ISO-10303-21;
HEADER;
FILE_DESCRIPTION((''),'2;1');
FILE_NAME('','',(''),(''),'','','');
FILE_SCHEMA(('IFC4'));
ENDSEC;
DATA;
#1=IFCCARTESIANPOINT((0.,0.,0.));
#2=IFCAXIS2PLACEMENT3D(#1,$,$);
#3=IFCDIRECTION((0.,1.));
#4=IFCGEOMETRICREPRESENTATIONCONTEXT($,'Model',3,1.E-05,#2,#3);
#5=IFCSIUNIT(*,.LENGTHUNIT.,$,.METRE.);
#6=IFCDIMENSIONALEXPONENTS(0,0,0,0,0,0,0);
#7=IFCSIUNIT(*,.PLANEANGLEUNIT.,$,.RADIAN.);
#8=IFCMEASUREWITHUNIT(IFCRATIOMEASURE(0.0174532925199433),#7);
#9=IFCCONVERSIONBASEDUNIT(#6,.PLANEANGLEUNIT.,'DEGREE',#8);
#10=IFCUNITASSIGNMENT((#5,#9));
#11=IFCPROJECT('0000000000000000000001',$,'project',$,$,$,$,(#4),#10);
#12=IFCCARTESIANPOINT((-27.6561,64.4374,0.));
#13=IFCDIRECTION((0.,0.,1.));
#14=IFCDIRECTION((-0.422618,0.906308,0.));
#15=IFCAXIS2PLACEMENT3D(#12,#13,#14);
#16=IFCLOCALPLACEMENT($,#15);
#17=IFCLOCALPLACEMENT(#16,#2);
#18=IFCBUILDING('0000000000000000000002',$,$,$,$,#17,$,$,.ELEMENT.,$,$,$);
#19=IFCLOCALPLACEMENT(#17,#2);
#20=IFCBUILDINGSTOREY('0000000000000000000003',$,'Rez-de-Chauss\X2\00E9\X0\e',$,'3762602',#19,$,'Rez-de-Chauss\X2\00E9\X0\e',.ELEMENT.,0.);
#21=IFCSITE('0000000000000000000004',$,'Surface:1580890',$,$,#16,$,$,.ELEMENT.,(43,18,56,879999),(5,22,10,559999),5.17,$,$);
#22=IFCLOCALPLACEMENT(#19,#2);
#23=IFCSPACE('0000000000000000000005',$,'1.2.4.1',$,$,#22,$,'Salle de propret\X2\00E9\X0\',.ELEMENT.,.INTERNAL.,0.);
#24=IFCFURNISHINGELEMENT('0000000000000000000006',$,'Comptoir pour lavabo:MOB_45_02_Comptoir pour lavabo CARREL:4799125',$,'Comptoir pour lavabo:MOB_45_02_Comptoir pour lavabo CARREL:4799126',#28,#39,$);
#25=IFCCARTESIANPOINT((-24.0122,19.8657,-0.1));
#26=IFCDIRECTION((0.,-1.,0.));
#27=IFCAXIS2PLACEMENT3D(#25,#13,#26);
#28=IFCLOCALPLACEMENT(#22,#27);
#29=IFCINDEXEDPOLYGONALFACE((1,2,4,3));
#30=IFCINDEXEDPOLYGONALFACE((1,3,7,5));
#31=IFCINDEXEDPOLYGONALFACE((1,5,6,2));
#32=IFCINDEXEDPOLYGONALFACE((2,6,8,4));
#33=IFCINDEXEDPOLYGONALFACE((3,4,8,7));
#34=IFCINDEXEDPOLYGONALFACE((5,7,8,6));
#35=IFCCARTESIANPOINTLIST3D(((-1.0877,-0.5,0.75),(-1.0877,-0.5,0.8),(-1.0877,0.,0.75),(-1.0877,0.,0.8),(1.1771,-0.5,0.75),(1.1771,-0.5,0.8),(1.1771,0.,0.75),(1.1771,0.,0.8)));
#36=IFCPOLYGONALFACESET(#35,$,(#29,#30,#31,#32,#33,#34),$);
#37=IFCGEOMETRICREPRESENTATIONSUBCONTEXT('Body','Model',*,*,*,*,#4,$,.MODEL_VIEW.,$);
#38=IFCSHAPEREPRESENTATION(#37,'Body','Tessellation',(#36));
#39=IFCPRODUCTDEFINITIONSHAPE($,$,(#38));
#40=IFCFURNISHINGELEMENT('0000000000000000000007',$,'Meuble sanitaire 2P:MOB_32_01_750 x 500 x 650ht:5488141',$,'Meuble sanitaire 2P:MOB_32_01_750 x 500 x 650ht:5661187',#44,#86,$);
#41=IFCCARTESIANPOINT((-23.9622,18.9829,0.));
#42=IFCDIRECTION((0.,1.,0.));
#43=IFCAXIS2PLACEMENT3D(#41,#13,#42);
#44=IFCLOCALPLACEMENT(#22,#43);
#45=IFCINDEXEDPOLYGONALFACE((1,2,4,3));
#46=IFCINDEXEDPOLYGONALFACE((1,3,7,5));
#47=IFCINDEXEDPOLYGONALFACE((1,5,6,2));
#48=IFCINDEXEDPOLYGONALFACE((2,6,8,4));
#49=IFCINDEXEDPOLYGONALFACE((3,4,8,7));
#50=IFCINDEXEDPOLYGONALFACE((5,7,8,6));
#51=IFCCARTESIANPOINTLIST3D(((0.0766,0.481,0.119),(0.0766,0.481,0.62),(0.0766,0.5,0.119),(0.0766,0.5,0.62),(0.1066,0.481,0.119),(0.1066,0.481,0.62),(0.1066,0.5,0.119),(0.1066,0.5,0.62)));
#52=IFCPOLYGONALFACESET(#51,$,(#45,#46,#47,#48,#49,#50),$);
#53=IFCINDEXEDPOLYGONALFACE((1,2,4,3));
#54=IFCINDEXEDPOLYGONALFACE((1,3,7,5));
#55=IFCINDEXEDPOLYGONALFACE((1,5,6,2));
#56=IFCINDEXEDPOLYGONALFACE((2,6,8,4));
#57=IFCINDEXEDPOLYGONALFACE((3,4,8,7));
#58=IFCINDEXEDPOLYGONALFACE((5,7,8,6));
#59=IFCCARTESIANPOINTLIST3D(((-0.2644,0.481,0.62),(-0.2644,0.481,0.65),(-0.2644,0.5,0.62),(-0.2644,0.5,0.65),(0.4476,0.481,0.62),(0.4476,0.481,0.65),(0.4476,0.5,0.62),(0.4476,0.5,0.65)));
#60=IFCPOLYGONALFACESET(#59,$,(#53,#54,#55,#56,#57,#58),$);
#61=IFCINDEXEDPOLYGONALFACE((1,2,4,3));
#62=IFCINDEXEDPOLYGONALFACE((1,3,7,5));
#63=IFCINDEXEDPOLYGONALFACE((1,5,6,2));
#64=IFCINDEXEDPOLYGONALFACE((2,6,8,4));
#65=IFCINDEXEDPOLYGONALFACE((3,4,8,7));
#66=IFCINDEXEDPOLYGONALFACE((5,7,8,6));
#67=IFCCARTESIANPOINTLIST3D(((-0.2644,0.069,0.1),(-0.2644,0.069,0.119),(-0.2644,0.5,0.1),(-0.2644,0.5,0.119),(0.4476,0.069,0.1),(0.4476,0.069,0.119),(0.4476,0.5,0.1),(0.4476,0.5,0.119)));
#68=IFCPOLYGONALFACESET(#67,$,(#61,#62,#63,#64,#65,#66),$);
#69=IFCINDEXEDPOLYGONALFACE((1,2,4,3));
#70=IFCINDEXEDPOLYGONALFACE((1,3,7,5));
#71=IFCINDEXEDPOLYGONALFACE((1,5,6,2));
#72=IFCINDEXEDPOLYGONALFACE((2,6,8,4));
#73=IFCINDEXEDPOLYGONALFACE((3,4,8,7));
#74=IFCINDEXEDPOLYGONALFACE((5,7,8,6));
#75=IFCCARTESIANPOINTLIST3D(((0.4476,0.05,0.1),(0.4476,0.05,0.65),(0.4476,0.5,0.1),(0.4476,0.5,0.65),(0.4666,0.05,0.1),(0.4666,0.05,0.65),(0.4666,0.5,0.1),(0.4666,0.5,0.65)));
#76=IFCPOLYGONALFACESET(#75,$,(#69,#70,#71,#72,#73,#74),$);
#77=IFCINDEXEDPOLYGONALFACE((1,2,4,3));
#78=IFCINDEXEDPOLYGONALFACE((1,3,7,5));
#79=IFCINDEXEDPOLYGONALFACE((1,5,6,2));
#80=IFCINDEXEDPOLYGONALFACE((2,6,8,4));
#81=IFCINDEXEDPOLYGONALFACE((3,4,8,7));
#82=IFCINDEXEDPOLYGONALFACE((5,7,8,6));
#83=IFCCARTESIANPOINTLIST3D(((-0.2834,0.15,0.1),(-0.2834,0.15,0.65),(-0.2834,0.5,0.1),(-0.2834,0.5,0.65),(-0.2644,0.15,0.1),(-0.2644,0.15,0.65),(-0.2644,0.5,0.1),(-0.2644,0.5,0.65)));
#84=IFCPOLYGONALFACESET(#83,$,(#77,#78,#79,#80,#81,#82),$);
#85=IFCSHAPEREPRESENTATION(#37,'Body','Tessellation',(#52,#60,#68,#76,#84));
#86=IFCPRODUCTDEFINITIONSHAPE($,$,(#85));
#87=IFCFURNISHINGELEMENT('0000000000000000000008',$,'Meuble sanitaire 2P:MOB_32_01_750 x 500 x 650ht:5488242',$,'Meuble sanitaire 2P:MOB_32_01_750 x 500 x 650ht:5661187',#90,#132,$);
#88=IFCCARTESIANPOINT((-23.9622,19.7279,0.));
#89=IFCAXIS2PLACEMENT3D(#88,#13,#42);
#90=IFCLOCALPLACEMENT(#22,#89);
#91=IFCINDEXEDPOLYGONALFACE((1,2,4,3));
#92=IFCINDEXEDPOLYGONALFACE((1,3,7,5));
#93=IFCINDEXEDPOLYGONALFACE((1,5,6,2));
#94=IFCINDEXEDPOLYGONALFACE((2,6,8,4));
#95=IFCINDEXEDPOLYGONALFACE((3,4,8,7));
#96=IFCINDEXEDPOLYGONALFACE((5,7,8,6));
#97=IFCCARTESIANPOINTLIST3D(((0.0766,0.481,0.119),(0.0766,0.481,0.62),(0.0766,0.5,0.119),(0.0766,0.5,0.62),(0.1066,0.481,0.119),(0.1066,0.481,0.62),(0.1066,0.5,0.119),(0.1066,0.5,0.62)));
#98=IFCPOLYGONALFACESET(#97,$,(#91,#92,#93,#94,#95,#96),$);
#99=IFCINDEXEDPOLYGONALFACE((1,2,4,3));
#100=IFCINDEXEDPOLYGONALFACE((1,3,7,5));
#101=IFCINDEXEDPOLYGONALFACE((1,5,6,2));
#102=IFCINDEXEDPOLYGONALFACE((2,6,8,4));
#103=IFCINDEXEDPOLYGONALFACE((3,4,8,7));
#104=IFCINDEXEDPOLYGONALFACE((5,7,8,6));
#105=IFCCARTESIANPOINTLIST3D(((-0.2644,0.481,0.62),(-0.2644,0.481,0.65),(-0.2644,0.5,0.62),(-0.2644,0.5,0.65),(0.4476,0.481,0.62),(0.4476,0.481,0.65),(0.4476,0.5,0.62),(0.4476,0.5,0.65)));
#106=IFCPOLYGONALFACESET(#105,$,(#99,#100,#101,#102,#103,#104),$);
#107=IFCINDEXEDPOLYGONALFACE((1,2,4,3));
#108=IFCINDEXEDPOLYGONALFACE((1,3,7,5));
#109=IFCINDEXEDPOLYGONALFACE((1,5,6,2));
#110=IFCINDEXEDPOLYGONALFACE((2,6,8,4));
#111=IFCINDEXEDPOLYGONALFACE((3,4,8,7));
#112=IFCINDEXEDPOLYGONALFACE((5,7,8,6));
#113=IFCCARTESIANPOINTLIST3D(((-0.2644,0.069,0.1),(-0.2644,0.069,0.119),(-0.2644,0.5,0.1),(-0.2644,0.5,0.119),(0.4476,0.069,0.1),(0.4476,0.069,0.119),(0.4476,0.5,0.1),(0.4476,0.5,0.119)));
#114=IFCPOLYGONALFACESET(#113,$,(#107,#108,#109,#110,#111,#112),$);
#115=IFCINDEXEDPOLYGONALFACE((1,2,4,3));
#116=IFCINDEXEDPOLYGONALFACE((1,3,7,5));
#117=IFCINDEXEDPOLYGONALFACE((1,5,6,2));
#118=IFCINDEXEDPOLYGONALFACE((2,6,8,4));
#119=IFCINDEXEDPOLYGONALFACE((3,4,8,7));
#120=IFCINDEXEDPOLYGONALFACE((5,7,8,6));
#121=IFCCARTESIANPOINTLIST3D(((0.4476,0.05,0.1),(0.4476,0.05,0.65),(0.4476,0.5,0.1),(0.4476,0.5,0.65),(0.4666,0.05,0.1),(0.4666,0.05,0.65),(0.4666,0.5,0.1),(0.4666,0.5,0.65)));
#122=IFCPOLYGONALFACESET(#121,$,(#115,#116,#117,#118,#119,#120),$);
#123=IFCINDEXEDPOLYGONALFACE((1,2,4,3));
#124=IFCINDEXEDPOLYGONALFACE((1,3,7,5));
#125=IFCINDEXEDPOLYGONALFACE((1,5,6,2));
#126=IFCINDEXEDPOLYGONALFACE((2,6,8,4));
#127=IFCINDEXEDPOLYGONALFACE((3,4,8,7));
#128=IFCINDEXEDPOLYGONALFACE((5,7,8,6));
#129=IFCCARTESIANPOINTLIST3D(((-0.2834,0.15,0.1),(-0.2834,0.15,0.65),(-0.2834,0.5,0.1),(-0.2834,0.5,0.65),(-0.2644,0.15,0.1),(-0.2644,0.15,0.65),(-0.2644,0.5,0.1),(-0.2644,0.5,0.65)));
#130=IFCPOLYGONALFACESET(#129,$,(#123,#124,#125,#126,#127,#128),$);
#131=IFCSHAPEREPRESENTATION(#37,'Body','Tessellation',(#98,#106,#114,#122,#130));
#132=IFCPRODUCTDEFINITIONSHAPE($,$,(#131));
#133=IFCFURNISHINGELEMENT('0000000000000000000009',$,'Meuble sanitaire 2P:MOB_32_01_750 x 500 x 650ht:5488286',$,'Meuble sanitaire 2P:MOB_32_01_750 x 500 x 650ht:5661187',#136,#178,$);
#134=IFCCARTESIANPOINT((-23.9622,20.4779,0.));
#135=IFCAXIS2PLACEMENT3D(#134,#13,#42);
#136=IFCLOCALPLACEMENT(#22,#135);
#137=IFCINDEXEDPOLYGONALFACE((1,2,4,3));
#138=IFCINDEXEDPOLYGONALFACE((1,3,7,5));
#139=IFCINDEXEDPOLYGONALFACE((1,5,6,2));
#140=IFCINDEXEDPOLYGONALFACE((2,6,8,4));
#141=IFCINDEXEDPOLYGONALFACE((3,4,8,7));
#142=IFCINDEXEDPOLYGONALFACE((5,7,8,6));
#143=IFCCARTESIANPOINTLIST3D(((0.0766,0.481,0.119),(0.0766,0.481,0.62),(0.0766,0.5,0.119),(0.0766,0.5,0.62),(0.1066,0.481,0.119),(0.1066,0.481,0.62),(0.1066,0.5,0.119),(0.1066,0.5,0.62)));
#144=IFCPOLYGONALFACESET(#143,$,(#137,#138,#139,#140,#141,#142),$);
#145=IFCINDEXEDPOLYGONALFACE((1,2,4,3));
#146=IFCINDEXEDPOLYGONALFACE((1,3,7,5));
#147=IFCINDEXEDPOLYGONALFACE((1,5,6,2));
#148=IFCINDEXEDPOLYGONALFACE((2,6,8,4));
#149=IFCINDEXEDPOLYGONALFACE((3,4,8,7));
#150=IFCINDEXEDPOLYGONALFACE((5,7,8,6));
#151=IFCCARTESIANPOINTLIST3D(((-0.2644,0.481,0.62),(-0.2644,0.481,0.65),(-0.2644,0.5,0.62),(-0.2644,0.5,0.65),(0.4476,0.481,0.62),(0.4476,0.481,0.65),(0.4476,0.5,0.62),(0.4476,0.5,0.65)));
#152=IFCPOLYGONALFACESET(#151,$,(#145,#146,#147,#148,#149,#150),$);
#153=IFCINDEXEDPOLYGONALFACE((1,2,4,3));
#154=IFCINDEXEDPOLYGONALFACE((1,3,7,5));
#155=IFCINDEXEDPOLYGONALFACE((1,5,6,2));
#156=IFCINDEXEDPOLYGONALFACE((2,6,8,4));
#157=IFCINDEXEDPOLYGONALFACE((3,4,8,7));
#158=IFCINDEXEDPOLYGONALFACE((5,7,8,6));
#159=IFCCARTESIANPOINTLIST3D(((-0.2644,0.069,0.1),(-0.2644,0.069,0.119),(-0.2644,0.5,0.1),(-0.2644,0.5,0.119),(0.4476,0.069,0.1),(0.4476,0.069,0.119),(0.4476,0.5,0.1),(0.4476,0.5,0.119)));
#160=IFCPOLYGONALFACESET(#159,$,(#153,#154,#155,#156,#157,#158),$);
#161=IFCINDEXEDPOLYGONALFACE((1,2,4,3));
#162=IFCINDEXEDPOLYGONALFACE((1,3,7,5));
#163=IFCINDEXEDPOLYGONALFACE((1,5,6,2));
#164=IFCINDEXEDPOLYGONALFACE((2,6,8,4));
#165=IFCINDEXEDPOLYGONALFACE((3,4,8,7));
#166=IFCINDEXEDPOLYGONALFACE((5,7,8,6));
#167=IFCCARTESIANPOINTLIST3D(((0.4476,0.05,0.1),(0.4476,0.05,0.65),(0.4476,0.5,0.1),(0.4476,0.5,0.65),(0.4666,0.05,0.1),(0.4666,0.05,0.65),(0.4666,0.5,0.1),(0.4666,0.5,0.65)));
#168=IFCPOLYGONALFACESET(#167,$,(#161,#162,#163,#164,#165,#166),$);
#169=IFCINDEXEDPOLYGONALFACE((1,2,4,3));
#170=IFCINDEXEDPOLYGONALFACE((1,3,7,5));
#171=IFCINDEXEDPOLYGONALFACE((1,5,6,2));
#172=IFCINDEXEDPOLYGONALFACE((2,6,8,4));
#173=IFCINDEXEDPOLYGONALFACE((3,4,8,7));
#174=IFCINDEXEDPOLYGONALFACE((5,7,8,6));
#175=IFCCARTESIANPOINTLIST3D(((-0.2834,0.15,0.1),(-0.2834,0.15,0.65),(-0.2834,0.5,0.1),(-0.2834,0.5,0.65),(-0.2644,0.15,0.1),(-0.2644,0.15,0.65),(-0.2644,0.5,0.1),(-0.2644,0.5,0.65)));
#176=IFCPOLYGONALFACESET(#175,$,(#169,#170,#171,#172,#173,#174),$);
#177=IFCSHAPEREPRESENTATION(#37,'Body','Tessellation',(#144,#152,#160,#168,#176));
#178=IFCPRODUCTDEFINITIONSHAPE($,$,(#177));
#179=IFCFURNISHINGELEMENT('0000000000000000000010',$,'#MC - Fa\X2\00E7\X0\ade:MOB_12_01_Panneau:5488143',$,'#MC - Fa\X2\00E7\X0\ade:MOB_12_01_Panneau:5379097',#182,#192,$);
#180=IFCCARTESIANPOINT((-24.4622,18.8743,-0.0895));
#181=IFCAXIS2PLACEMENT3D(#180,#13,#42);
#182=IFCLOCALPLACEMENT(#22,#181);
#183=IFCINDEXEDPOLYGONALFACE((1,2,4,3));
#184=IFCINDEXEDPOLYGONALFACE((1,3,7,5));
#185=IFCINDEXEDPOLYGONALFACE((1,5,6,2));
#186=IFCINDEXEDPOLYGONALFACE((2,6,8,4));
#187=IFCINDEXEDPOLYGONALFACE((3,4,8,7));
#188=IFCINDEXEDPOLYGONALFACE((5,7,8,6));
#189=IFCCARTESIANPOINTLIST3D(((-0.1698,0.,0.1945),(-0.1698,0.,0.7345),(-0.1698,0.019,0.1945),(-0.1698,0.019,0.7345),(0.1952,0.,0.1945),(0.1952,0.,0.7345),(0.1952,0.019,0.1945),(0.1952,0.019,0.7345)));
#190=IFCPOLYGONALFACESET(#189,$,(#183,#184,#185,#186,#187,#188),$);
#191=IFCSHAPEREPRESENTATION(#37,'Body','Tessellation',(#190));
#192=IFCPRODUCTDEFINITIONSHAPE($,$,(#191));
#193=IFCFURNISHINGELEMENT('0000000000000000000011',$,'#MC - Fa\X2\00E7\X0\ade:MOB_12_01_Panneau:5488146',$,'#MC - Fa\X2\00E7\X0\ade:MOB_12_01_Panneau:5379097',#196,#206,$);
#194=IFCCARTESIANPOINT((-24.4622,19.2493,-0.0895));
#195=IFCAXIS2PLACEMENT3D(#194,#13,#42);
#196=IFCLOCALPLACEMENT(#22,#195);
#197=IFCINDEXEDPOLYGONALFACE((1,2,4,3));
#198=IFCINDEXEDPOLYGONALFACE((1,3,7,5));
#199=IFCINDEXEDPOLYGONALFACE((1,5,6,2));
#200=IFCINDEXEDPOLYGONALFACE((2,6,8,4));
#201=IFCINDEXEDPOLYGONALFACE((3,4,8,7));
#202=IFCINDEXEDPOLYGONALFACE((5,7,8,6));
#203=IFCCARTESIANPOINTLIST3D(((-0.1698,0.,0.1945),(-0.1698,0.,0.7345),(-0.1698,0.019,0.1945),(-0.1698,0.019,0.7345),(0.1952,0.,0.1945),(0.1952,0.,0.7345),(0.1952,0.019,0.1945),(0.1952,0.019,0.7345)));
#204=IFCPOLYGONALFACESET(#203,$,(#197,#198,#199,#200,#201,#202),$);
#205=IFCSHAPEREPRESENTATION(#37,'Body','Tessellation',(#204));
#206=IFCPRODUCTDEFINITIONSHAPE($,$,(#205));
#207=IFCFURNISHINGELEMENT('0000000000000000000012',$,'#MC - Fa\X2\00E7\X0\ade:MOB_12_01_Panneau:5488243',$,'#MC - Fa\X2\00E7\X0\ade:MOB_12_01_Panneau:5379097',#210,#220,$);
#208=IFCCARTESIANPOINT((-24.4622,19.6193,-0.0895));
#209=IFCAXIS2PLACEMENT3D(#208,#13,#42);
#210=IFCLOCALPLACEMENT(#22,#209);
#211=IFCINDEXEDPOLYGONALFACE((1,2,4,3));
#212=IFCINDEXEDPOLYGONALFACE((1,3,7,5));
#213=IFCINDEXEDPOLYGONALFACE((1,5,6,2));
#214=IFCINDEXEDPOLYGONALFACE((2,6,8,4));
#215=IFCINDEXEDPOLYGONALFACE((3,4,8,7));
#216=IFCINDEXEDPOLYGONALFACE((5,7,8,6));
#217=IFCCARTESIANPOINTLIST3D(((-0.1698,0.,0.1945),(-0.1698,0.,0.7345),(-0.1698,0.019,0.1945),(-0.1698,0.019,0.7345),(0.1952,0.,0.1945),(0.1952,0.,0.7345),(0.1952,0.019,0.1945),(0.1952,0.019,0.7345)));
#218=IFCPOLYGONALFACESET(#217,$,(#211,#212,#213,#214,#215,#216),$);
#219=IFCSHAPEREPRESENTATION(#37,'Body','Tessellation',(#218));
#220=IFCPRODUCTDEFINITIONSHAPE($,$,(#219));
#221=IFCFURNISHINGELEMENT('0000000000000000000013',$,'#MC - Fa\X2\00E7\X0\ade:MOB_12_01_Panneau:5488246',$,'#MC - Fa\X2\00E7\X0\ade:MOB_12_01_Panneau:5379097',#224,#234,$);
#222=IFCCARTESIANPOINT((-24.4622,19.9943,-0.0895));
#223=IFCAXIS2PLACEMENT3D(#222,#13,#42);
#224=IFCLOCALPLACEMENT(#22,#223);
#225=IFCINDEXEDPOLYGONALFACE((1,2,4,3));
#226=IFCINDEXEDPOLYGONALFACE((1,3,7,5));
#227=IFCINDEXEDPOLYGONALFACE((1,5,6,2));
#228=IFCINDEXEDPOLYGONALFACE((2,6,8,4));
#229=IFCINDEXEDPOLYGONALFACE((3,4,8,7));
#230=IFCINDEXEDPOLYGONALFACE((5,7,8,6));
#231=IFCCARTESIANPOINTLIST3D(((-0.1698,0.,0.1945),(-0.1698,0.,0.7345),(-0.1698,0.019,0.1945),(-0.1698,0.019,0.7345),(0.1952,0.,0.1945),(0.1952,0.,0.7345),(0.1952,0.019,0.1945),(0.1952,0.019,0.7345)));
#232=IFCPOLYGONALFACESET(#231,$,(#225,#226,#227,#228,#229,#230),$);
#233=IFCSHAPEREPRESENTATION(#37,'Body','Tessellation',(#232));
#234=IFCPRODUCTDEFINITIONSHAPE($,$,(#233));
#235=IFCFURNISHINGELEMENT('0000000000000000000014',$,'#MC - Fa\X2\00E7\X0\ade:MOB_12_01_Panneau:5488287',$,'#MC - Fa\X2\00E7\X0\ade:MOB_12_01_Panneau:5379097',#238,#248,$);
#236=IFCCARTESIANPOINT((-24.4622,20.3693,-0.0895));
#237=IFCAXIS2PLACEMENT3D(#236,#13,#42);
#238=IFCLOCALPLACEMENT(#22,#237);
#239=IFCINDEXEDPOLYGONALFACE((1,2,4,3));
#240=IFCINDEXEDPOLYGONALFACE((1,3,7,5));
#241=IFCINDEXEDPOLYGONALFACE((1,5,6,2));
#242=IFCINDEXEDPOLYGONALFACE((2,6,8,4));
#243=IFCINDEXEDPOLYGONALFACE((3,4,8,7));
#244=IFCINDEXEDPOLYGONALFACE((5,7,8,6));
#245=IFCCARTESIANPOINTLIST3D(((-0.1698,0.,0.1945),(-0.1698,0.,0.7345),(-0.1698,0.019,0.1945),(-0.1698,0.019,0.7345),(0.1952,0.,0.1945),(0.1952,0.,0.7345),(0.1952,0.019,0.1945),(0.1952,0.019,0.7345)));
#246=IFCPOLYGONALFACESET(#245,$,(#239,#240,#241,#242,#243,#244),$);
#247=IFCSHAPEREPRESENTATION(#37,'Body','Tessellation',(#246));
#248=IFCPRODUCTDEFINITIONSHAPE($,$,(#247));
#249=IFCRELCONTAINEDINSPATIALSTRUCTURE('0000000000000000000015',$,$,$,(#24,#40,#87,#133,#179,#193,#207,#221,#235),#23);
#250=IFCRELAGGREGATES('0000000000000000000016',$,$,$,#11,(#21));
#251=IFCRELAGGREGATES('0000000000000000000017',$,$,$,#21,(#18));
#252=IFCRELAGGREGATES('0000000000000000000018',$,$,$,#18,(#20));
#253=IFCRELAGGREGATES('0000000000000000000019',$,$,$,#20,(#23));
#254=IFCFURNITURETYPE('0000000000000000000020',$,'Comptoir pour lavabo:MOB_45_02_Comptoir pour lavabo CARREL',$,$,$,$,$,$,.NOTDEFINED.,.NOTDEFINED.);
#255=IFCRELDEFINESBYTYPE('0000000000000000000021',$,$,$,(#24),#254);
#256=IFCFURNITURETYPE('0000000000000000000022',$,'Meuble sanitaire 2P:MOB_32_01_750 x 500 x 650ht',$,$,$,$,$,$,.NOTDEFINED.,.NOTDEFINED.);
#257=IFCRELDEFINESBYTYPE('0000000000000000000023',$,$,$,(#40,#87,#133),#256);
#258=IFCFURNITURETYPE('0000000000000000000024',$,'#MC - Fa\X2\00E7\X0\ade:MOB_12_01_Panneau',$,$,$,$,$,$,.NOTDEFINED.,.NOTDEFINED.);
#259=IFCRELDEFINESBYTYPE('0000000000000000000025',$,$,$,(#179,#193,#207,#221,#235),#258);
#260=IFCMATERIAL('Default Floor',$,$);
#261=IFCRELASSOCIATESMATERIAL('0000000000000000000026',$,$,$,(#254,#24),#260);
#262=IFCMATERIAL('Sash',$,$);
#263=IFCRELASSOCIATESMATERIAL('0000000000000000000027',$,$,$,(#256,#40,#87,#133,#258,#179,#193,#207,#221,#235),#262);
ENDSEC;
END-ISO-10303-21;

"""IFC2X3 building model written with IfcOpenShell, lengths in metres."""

from ifc_helpers import new_model, entity, si_unit, converted_unit, direction, frame, frame_2d, origin, origin_2d_with_axis, place, context, subcontext, project, spatial, rectangle, extrude, source, transform, mapped, material, type_object, type_shapes, element, save


model = new_model("IFC2X3")

# Units and contexts
model_context = context("Model", 3, precision=1e-05, world=origin(), true_north=direction((0.0, 1.0)))
body_context = subcontext(model_context, "Body", "Model", "MODEL_VIEW")
ifc_project = project(units=[si_unit("LENGTHUNIT", "METRE"), converted_unit("PLANEANGLEUNIT", "DEGREE", entity("IfcRatioMeasure", 0.0174532925199433), si_unit("PLANEANGLEUNIT", "RADIAN"), dimensions=[0, 0, 0, 0, 0, 0, 0])], contexts=[model_context])

# Site, building, storey
site_placement = place(None, frame((-27.6561, 64.4374, 0.0), z_axis=(0.0, 0.0, 1.0), x_axis=(-0.422618, 0.906308, 0.0)))
site = spatial("IfcSite", under=ifc_project, at=site_placement, Name="Surface:1580890", CompositionType="ELEMENT", RefLatitude=(43, 18, 56, 879999), RefLongitude=(5, 22, 10, 559999), RefElevation=5.17)
building_placement = place(site_placement, origin())
building = spatial("IfcBuilding", under=site, at=building_placement, CompositionType="ELEMENT")
storey_placement = place(building_placement, origin())
storey = spatial("IfcBuildingStorey", under=building, at=storey_placement, Name="Rez-de-Chaussée", ObjectType="3762602", LongName="Rez-de-Chaussée", CompositionType="ELEMENT", Elevation=0.0)

# Shared definitions
ifc_material_1 = material(Name="Sash")

# Shared definitions
space_placement = place(storey_placement, origin())
space = spatial("IfcSpace", under=storey, at=space_placement, Name="1.2.4.1", LongName="Salle de propreté", CompositionType="ELEMENT", InteriorOrExteriorSpace="INTERNAL", ElevationWithFlooring=0.0)

# Furnishing elements
ifc_material_2 = material(Name="Default Floor")
furniture_type_1 = type_object("IfcFurnitureType", Name="Comptoir pour lavabo:MOB_45_02_Comptoir pour lavabo CARREL", material=ifc_material_2)
shared_shape_1 = source(origin(), body_context, "Body", "SweptSolid", [
    extrude(rectangle(XDim=2.2649, YDim=0.5, at=origin_2d_with_axis()), frame((0.0447, -0.25, 0.75), z_axis=(0.0, 0.0, 1.0), x_axis=(-1.0, 0.0, 0.0)), (0.0, 0.0, 1.0), 0.05),
])
type_shapes(furniture_type_1, [shared_shape_1])
furnishing_placement = place(space_placement, frame((-24.0122, 19.8657, -0.1), z_axis=(0.0, 0.0, 1.0), x_axis=(0.0, -1.0, 0.0)))
element("IfcFurnishingElement", 1, at=furnishing_placement, inside=space, type_object=furniture_type_1, material=ifc_material_2, Name="Comptoir pour lavabo:MOB_45_02_Comptoir pour lavabo CARREL:4799125", ObjectType="Comptoir pour lavabo:MOB_45_02_Comptoir pour lavabo CARREL:4799126", context=body_context, shape_type="MappedRepresentation", body=[
    mapped(shared_shape_1, transform((0.0, 0.0, 0.0), scale=1.0)),
])
furniture_type_2 = type_object("IfcFurnitureType", Name="Meuble sanitaire 2P:MOB_32_01_750 x 500 x 650ht", material=ifc_material_1)
shared_shape_2 = source(origin(), body_context, "Body", "SweptSolid", [
    extrude(rectangle(XDim=0.019, YDim=0.03, at=frame_2d((0.0, 0.0), x_axis=(1.0, 0.0))), frame((0.0916, 0.4905, 0.119), z_axis=(0.0, 0.0, 1.0), x_axis=(0.0, 1.0, 0.0)), (0.0, 0.0, 1.0), 0.501),
    extrude(rectangle(XDim=0.019, YDim=0.712, at=origin_2d_with_axis()), frame((0.0916, 0.4905, 0.62), z_axis=(0.0, 0.0, 1.0), x_axis=(0.0, 1.0, 0.0)), (0.0, 0.0, 1.0), 0.03),
    extrude(rectangle(XDim=0.712, YDim=0.431, at=origin_2d_with_axis()), frame((0.0916, 0.2845, 0.1), z_axis=(0.0, 0.0, 1.0), x_axis=(-1.0, 0.0, 0.0)), (0.0, 0.0, 1.0), 0.019),
    extrude(rectangle(XDim=0.019, YDim=0.45, at=origin_2d_with_axis()), frame((0.4571, 0.275, 0.1), z_axis=(0.0, 0.0, 1.0), x_axis=(-1.0, 0.0, 0.0)), (0.0, 0.0, 1.0), 0.55),
    extrude(rectangle(XDim=0.019, YDim=0.35, at=origin_2d_with_axis()), frame((-0.2739, 0.325, 0.1), z_axis=(0.0, 0.0, 1.0), x_axis=(-1.0, 0.0, 0.0)), (0.0, 0.0, 1.0), 0.55),
])
type_shapes(furniture_type_2, [shared_shape_2])
for number, where, z_axis, x_axis, name in (
    (2, (-23.9622, 18.9829, 0.0), (0.0, 0.0, 1.0), (0.0, 1.0, 0.0), "Meuble sanitaire 2P:MOB_32_01_750 x 500 x 650ht:5488141"),
    (3, (-23.9622, 19.7279, 0.0), (0.0, 0.0, 1.0), (0.0, 1.0, 0.0), "Meuble sanitaire 2P:MOB_32_01_750 x 500 x 650ht:5488242"),
    (4, (-23.9622, 20.4779, 0.0), (0.0, 0.0, 1.0), (0.0, 1.0, 0.0), "Meuble sanitaire 2P:MOB_32_01_750 x 500 x 650ht:5488286"),
):
    element("IfcFurnishingElement", number, at=place(space_placement, frame(where, z_axis=z_axis, x_axis=x_axis)), inside=space, type_object=furniture_type_2, material=ifc_material_1, Name=name, ObjectType="Meuble sanitaire 2P:MOB_32_01_750 x 500 x 650ht:5661187", context=body_context, shape_type="MappedRepresentation", body=[
        mapped(shared_shape_2, transform((0.0, 0.0, 0.0), scale=1.0)),
    ])
furniture_type_3 = type_object("IfcFurnitureType", Name="#MC - Façade:MOB_12_01_Panneau", material=ifc_material_1)
shared_shape_3 = source(origin(), body_context, "Body", "SweptSolid", [
    extrude(rectangle(XDim=0.019, YDim=0.365, at=origin_2d_with_axis()), frame((0.0127, 0.0095, 0.1945), z_axis=(0.0, 0.0, 1.0), x_axis=(0.0, 1.0, 0.0)), (0.0, 0.0, 1.0), 0.54),
])
type_shapes(furniture_type_3, [shared_shape_3])
for number, where, z_axis, x_axis, name in (
    (5, (-24.4622, 18.8743, -0.0895), (0.0, 0.0, 1.0), (0.0, 1.0, 0.0), "#MC - Façade:MOB_12_01_Panneau:5488143"),
    (6, (-24.4622, 19.2493, -0.0895), (0.0, 0.0, 1.0), (0.0, 1.0, 0.0), "#MC - Façade:MOB_12_01_Panneau:5488146"),
    (7, (-24.4622, 19.6193, -0.0895), (0.0, 0.0, 1.0), (0.0, 1.0, 0.0), "#MC - Façade:MOB_12_01_Panneau:5488243"),
    (8, (-24.4622, 19.9943, -0.0895), (0.0, 0.0, 1.0), (0.0, 1.0, 0.0), "#MC - Façade:MOB_12_01_Panneau:5488246"),
    (9, (-24.4622, 20.3693, -0.0895), (0.0, 0.0, 1.0), (0.0, 1.0, 0.0), "#MC - Façade:MOB_12_01_Panneau:5488287"),
):
    element("IfcFurnishingElement", number, at=place(space_placement, frame(where, z_axis=z_axis, x_axis=x_axis)), inside=space, type_object=furniture_type_3, material=ifc_material_1, Name=name, ObjectType="#MC - Façade:MOB_12_01_Panneau:5379097", context=body_context, shape_type="MappedRepresentation", body=[
        mapped(shared_shape_3, transform((0.0, 0.0, 0.0), scale=1.0)),
    ])

save(model, "model.ifc")
